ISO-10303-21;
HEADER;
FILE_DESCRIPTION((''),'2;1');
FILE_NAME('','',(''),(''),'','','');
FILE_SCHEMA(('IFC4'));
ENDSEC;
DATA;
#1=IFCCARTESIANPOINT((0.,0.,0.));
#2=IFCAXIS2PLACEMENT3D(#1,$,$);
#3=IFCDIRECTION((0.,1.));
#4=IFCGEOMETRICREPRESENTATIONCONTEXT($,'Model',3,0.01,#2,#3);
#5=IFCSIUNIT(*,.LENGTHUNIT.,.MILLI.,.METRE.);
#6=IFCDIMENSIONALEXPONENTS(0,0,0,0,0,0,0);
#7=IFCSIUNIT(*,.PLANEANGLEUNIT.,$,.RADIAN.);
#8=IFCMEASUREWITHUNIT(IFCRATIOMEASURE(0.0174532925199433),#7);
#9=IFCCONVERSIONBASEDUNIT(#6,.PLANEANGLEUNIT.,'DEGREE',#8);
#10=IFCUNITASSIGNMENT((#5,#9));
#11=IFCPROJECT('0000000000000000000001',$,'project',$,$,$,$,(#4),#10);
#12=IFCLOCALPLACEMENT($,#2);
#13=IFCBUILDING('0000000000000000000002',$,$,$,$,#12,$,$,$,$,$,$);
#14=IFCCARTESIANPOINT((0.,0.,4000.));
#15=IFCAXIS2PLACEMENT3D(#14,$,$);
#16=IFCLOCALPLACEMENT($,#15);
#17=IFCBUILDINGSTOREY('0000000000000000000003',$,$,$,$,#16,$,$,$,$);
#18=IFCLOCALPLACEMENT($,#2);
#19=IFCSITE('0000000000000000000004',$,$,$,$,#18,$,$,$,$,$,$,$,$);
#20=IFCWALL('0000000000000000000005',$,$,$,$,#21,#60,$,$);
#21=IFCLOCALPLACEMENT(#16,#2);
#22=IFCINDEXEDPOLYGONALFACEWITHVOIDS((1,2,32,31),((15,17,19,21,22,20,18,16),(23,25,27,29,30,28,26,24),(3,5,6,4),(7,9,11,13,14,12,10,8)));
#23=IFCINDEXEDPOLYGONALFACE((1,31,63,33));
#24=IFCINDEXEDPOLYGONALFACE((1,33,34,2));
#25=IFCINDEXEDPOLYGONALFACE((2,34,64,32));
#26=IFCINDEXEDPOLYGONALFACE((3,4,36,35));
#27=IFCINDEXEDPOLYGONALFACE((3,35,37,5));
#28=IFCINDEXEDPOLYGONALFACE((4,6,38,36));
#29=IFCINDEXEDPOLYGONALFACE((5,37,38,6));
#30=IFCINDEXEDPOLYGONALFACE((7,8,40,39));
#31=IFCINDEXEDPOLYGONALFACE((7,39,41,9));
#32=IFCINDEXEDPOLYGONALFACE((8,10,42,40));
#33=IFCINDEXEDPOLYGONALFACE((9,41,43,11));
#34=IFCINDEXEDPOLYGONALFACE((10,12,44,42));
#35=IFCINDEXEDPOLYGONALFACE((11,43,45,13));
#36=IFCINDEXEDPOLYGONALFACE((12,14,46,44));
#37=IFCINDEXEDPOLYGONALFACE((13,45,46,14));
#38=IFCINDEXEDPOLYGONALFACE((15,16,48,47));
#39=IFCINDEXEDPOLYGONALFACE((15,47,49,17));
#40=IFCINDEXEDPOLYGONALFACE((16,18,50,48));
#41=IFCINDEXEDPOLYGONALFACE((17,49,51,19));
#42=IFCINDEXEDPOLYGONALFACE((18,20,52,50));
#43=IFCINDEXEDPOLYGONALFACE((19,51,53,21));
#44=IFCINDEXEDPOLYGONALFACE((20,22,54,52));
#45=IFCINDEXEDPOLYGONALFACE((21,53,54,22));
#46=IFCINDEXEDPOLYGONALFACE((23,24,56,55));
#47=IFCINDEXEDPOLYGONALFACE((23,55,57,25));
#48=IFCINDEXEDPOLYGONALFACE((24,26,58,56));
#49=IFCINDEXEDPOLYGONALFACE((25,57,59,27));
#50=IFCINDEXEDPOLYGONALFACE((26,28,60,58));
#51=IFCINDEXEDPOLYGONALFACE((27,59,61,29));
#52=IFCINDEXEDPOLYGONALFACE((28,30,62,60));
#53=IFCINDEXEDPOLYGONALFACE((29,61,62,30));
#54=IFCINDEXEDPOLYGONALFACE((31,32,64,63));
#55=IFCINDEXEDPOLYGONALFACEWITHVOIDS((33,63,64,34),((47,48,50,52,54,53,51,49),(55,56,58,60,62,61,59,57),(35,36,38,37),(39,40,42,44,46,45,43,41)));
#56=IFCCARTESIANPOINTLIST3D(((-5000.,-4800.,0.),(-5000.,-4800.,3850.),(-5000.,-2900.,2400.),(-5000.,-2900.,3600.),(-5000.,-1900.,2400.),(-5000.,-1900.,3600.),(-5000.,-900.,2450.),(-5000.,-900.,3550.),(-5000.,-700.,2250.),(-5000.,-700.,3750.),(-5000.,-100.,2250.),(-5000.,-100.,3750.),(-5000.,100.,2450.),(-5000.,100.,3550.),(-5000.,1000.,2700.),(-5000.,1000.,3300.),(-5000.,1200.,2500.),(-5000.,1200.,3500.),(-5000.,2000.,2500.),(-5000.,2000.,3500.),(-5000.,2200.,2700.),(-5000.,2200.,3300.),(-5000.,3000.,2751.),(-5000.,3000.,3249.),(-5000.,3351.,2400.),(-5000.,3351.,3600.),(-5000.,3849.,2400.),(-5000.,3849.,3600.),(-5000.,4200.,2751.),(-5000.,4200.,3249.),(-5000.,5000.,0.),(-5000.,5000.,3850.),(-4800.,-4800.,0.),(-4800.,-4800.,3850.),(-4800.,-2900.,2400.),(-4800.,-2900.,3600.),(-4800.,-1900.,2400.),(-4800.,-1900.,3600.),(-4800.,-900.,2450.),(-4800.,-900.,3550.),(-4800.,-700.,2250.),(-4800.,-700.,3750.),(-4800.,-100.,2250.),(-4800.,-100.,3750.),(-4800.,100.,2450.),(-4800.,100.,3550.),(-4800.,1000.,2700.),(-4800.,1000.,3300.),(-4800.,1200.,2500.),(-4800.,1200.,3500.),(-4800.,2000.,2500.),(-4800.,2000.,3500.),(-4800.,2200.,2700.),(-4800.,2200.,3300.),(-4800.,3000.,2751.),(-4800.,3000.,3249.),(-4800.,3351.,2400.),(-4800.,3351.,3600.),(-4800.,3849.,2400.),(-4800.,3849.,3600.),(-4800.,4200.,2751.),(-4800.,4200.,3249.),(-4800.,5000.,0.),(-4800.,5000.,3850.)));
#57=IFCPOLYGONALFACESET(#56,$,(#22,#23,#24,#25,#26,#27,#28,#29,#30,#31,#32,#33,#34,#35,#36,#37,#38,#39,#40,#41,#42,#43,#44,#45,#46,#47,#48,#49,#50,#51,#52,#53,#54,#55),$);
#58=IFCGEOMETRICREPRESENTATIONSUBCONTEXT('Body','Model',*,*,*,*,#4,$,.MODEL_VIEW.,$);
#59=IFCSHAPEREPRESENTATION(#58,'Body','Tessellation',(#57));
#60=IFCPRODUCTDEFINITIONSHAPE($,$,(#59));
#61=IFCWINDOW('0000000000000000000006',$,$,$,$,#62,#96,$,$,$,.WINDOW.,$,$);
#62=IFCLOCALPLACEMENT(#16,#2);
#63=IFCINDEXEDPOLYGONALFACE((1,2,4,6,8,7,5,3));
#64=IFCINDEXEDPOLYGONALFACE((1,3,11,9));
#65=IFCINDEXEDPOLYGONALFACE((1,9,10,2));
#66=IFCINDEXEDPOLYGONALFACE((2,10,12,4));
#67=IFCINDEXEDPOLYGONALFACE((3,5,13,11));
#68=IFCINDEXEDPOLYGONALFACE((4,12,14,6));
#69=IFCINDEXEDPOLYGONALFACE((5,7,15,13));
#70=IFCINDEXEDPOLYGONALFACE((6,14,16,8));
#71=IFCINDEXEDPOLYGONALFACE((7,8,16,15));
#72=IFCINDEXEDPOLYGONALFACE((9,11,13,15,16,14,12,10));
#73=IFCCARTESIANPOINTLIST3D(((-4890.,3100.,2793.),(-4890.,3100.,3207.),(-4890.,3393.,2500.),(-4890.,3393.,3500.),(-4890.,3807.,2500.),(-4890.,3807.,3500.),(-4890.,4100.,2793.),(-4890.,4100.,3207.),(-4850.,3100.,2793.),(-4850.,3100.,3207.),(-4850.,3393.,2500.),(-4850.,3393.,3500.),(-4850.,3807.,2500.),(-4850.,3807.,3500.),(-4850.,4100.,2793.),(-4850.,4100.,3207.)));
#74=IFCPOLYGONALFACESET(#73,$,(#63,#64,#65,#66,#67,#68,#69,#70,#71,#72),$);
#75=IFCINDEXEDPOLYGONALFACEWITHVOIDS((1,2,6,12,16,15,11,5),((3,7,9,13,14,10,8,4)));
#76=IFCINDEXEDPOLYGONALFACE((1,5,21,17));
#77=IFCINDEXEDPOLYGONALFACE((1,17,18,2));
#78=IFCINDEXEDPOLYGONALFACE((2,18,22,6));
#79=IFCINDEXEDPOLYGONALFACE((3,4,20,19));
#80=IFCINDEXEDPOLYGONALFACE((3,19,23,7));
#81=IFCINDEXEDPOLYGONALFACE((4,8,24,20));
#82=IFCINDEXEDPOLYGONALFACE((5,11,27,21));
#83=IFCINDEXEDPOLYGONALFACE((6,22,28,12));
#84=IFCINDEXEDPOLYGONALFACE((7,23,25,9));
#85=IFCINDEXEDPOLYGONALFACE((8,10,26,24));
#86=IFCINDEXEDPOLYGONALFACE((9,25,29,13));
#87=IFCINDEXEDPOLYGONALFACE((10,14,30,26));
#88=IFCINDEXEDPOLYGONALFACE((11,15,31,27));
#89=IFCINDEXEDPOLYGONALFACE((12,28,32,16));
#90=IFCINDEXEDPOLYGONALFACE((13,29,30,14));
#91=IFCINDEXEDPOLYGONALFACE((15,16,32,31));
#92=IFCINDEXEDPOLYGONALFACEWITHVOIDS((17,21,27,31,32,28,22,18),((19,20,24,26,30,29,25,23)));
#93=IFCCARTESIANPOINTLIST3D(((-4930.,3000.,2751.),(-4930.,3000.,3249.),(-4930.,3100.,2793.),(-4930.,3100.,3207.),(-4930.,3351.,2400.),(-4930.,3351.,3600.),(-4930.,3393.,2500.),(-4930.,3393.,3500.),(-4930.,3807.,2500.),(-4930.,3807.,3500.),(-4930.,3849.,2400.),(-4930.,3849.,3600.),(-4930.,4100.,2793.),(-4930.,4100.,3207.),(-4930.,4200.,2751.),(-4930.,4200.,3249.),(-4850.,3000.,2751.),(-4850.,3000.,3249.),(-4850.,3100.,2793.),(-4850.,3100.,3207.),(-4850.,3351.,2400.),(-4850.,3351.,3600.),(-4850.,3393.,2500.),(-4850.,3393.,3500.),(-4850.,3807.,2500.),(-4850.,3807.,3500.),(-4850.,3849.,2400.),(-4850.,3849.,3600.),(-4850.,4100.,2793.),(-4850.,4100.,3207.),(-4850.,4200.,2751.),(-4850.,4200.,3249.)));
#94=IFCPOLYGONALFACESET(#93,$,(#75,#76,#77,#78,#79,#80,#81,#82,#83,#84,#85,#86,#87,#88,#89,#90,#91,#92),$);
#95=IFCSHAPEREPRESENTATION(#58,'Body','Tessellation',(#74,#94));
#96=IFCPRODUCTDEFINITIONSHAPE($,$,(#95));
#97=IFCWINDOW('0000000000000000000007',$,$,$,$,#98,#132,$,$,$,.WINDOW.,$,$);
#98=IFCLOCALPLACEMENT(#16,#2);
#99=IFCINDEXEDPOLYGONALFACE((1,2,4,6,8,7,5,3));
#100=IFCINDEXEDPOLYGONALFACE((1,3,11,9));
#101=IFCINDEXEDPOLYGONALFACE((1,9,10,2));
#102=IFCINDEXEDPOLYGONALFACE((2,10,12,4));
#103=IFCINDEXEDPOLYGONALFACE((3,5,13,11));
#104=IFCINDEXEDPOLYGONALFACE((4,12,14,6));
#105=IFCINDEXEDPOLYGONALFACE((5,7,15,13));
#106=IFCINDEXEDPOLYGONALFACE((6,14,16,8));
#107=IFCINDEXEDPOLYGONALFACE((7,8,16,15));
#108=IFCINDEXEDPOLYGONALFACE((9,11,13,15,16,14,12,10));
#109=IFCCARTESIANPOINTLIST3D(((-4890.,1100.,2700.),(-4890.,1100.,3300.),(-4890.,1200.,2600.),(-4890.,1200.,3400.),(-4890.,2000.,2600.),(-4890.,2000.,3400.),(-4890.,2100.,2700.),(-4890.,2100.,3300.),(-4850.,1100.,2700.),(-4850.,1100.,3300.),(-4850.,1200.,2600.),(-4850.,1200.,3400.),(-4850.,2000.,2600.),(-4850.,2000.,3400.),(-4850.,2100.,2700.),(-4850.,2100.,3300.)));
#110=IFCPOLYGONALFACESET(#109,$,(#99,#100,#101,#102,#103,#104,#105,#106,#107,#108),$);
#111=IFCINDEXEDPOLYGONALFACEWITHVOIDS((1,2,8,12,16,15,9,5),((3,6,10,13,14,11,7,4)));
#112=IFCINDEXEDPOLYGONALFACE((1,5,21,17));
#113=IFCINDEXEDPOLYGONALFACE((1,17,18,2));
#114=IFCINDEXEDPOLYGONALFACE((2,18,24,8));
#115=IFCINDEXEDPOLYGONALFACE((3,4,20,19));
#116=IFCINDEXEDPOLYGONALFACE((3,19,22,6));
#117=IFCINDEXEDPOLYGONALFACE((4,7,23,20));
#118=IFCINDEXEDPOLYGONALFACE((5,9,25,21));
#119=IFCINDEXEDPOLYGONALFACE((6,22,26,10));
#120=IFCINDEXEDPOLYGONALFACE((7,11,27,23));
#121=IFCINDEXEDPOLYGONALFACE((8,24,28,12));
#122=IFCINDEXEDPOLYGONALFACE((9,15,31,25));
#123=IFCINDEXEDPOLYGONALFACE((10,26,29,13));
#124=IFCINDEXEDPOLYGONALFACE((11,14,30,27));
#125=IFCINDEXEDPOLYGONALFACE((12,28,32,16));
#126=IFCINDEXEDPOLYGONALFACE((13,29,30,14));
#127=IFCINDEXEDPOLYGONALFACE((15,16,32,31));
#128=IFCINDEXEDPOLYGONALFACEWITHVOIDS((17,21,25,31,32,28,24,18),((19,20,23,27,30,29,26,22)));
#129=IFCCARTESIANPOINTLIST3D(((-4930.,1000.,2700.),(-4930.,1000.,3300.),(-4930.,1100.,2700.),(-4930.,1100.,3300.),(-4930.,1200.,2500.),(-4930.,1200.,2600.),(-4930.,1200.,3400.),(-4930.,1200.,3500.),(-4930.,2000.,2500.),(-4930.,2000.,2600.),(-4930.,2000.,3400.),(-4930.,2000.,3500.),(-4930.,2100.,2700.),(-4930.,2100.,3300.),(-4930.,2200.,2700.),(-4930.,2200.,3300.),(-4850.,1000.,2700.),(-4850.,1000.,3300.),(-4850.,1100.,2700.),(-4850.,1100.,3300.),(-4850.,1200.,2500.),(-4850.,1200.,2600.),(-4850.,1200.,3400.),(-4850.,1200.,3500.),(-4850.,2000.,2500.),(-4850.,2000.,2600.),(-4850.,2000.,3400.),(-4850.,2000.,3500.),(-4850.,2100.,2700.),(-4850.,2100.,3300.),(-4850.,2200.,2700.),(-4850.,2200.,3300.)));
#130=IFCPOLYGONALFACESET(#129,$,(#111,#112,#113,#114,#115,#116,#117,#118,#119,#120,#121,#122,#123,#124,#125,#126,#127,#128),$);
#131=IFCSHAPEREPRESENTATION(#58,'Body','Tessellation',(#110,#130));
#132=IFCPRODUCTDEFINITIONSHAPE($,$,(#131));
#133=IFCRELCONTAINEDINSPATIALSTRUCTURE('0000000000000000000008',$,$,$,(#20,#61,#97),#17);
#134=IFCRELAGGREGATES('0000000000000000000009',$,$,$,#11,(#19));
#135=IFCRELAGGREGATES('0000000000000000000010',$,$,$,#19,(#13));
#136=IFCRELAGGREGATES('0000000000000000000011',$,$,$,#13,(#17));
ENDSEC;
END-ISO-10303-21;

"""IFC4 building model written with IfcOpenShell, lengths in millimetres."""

from ifc_helpers import new_model, entity, si_unit, converted_unit, direction, frame, origin, origin_2d, place, context, subcontext, project, spatial, polyline, rectangle, outline, extrude, element, save


model = new_model("IFC4")

# Units and contexts
model_context = context("Model", 3, precision=0.01, world=origin(), true_north=direction((0.0, 1.0)))
body_context = subcontext(model_context, "Body", "Model", "MODEL_VIEW")
ifc_project = project(units=[si_unit("LENGTHUNIT", "METRE", prefix="MILLI"), converted_unit("PLANEANGLEUNIT", "DEGREE", entity("IfcRatioMeasure", 0.0174532925199433), si_unit("PLANEANGLEUNIT", "RADIAN"), dimensions=[0, 0, 0, 0, 0, 0, 0])], contexts=[model_context])

# Site, building, storey
site_placement = place(None, origin())
site = spatial("IfcSite", under=ifc_project, at=site_placement)
building_placement = place(None, origin())
building = spatial("IfcBuilding", under=site, at=building_placement)
storey_placement = place(None, frame((0.0, 0.0, 4000.0)))
storey = spatial("IfcBuildingStorey", under=building, at=storey_placement)

# Shared definitions
cartesian_point_1 = entity("IfcCartesianPoint", [-500.0, -207.0])
shared_polyline_1 = entity("IfcPolyline", [cartesian_point_1, entity("IfcCartesianPoint", [-500.0, 207.0]), entity("IfcCartesianPoint", [-207.0, 500.0]), entity("IfcCartesianPoint", [207.0, 500.0]), entity("IfcCartesianPoint", [500.0, 207.0]), entity("IfcCartesianPoint", [500.0, -207.0]), entity("IfcCartesianPoint", [207.0, -500.0]), entity("IfcCartesianPoint", [-207.0, -500.0]), cartesian_point_1])
cartesian_point_2 = entity("IfcCartesianPoint", [-500.0, -300.0])
shared_polyline_2 = entity("IfcPolyline", [cartesian_point_2, entity("IfcCartesianPoint", [-500.0, 300.0]), entity("IfcCartesianPoint", [-400.0, 400.0]), entity("IfcCartesianPoint", [400.0, 400.0]), entity("IfcCartesianPoint", [500.0, 300.0]), entity("IfcCartesianPoint", [500.0, -300.0]), entity("IfcCartesianPoint", [400.0, -400.0]), entity("IfcCartesianPoint", [-400.0, -400.0]), cartesian_point_2])

# Wall, openings
wall_1_placement = place(storey_placement, frame((-4900.0, 100.0, 0.0), z_axis=(0.0, 0.0, 1.0), x_axis=(0.0, -1.0, 0.0)))
wall_1 = element("IfcWall", 1, at=wall_1_placement, inside=storey, context=body_context, shape_type="SweptSolid", body=[
    extrude(rectangle(XDim=9800.0, YDim=200.0, at=origin_2d()), origin(), (0.0, 0.0, 1.0), 3850.0),
])
window_1_placement = place(wall_1_placement, frame((-3500.0, 50.0, 3000.0)))
opening_1_placement = place(window_1_placement, frame((0.0, 50.0, 0.0)))
element("IfcOpeningElement", 2, at=opening_1_placement, cuts=wall_1, context=body_context, shape_type="SweptSolid", body=[
    extrude(outline(polyline([(-600.0, -249.0), (-600.0, 249.0), (-249.0, 600.0), (249.0, 600.0), (600.0, 249.0), (600.0, -249.0), (249.0, -600.0), (-249.0, -600.0), (-600.0, -249.0)])), frame((0.0, 0.0, 0.0), z_axis=(0.0, -1.0, 0.0), x_axis=(1.0, 0.0, 0.0)), (0.0, 0.0, 1.0), 200.0),
])
window_2_placement = place(wall_1_placement, frame((-1500.0, 50.0, 3000.0)))
opening_2_placement = place(window_2_placement, frame((0.0, 50.0, 0.0)))
element("IfcOpeningElement", 3, at=opening_2_placement, cuts=wall_1, context=body_context, shape_type="SweptSolid", body=[
    extrude(outline(polyline([(-600.0, -300.0), (-600.0, 300.0), (-400.0, 500.0), (400.0, 500.0), (600.0, 300.0), (600.0, -300.0), (400.0, -500.0), (-400.0, -500.0), (-600.0, -300.0)])), frame((0.0, 0.0, 0.0), z_axis=(0.0, -1.0, 0.0), x_axis=(1.0, 0.0, 0.0)), (0.0, 0.0, 1.0), 200.0),
])
window_3_placement = place(wall_1_placement, frame((500.0, 50.0, 3000.0)))
opening_3_placement = place(window_3_placement, frame((0.0, 50.0, 0.0)))
element("IfcOpeningElement", 4, at=opening_3_placement, cuts=wall_1, context=body_context, shape_type="SweptSolid", body=[
    extrude(outline(polyline([(-500.0, -550.0), (-500.0, 550.0), (-300.0, 750.0), (300.0, 750.0), (500.0, 550.0), (500.0, -550.0), (300.0, -750.0), (-300.0, -750.0), (-500.0, -550.0)])), frame((0.0, 0.0, 0.0), z_axis=(0.0, -1.0, 0.0), x_axis=(1.0, 0.0, 0.0)), (0.0, 0.0, 1.0), 200.0),
])
window_4_placement = place(wall_1_placement, frame((2500.0, 50.0, 3000.0)))
opening_4_placement = place(window_4_placement, frame((0.0, 50.0, 0.0)))
element("IfcOpeningElement", 5, at=opening_4_placement, cuts=wall_1, context=body_context, shape_type="SweptSolid", body=[
    extrude(outline(polyline([(-500.0, -600.0), (-500.0, 600.0), (-500.0, 600.0), (500.0, 600.0), (500.0, 600.0), (500.0, -600.0), (500.0, -600.0), (-500.0, -600.0), (-500.0, -600.0)])), frame((0.0, 0.0, 0.0), z_axis=(0.0, -1.0, 0.0), x_axis=(1.0, 0.0, 0.0)), (0.0, 0.0, 1.0), 200.0),
])

# Windows
cartesian_point_3 = entity("IfcCartesianPoint", [-600.0, -249.0])
element("IfcWindow", 6, at=window_1_placement, inside=storey, PredefinedType="WINDOW", context=body_context, shape_type="SweptSolid", body=[
    entity("IfcExtrudedAreaSolid", entity("IfcArbitraryClosedProfileDef", "AREA", None, shared_polyline_1), entity("IfcAxis2Placement3D", entity("IfcCartesianPoint", [0.0, 0.0, 0.0]), entity("IfcDirection", [0.0, -1.0, 0.0]), entity("IfcDirection", [1.0, 0.0, 0.0])), entity("IfcDirection", [0.0, 0.0, 1.0]), 40.0),
    entity("IfcExtrudedAreaSolid", entity("IfcArbitraryProfileDefWithVoids", "AREA", None, entity("IfcPolyline", [cartesian_point_3, entity("IfcCartesianPoint", [-600.0, 249.0]), entity("IfcCartesianPoint", [-249.0, 600.0]), entity("IfcCartesianPoint", [249.0, 600.0]), entity("IfcCartesianPoint", [600.0, 249.0]), entity("IfcCartesianPoint", [600.0, -249.0]), entity("IfcCartesianPoint", [249.0, -600.0]), entity("IfcCartesianPoint", [-249.0, -600.0]), cartesian_point_3]), [shared_polyline_1]), entity("IfcAxis2Placement3D", entity("IfcCartesianPoint", [0.0, 0.0, 0.0]), entity("IfcDirection", [0.0, -1.0, 0.0]), entity("IfcDirection", [1.0, 0.0, 0.0])), entity("IfcDirection", [0.0, 0.0, 1.0]), 80.0),
])
cartesian_point_4 = entity("IfcCartesianPoint", [-600.0, -300.0])
element("IfcWindow", 7, at=window_2_placement, inside=storey, PredefinedType="WINDOW", context=body_context, shape_type="SweptSolid", body=[
    entity("IfcExtrudedAreaSolid", entity("IfcArbitraryClosedProfileDef", "AREA", None, shared_polyline_2), entity("IfcAxis2Placement3D", entity("IfcCartesianPoint", [0.0, 0.0, 0.0]), entity("IfcDirection", [0.0, -1.0, 0.0]), entity("IfcDirection", [1.0, 0.0, 0.0])), entity("IfcDirection", [0.0, 0.0, 1.0]), 40.0),
    entity("IfcExtrudedAreaSolid", entity("IfcArbitraryProfileDefWithVoids", "AREA", None, entity("IfcPolyline", [cartesian_point_4, entity("IfcCartesianPoint", [-600.0, 300.0]), entity("IfcCartesianPoint", [-400.0, 500.0]), entity("IfcCartesianPoint", [400.0, 500.0]), entity("IfcCartesianPoint", [600.0, 300.0]), entity("IfcCartesianPoint", [600.0, -300.0]), entity("IfcCartesianPoint", [400.0, -500.0]), entity("IfcCartesianPoint", [-400.0, -500.0]), cartesian_point_4]), [shared_polyline_2]), entity("IfcAxis2Placement3D", entity("IfcCartesianPoint", [0.0, 0.0, 0.0]), entity("IfcDirection", [0.0, -1.0, 0.0]), entity("IfcDirection", [1.0, 0.0, 0.0])), entity("IfcDirection", [0.0, 0.0, 1.0]), 80.0),
])

save(model, "model.ifc")
